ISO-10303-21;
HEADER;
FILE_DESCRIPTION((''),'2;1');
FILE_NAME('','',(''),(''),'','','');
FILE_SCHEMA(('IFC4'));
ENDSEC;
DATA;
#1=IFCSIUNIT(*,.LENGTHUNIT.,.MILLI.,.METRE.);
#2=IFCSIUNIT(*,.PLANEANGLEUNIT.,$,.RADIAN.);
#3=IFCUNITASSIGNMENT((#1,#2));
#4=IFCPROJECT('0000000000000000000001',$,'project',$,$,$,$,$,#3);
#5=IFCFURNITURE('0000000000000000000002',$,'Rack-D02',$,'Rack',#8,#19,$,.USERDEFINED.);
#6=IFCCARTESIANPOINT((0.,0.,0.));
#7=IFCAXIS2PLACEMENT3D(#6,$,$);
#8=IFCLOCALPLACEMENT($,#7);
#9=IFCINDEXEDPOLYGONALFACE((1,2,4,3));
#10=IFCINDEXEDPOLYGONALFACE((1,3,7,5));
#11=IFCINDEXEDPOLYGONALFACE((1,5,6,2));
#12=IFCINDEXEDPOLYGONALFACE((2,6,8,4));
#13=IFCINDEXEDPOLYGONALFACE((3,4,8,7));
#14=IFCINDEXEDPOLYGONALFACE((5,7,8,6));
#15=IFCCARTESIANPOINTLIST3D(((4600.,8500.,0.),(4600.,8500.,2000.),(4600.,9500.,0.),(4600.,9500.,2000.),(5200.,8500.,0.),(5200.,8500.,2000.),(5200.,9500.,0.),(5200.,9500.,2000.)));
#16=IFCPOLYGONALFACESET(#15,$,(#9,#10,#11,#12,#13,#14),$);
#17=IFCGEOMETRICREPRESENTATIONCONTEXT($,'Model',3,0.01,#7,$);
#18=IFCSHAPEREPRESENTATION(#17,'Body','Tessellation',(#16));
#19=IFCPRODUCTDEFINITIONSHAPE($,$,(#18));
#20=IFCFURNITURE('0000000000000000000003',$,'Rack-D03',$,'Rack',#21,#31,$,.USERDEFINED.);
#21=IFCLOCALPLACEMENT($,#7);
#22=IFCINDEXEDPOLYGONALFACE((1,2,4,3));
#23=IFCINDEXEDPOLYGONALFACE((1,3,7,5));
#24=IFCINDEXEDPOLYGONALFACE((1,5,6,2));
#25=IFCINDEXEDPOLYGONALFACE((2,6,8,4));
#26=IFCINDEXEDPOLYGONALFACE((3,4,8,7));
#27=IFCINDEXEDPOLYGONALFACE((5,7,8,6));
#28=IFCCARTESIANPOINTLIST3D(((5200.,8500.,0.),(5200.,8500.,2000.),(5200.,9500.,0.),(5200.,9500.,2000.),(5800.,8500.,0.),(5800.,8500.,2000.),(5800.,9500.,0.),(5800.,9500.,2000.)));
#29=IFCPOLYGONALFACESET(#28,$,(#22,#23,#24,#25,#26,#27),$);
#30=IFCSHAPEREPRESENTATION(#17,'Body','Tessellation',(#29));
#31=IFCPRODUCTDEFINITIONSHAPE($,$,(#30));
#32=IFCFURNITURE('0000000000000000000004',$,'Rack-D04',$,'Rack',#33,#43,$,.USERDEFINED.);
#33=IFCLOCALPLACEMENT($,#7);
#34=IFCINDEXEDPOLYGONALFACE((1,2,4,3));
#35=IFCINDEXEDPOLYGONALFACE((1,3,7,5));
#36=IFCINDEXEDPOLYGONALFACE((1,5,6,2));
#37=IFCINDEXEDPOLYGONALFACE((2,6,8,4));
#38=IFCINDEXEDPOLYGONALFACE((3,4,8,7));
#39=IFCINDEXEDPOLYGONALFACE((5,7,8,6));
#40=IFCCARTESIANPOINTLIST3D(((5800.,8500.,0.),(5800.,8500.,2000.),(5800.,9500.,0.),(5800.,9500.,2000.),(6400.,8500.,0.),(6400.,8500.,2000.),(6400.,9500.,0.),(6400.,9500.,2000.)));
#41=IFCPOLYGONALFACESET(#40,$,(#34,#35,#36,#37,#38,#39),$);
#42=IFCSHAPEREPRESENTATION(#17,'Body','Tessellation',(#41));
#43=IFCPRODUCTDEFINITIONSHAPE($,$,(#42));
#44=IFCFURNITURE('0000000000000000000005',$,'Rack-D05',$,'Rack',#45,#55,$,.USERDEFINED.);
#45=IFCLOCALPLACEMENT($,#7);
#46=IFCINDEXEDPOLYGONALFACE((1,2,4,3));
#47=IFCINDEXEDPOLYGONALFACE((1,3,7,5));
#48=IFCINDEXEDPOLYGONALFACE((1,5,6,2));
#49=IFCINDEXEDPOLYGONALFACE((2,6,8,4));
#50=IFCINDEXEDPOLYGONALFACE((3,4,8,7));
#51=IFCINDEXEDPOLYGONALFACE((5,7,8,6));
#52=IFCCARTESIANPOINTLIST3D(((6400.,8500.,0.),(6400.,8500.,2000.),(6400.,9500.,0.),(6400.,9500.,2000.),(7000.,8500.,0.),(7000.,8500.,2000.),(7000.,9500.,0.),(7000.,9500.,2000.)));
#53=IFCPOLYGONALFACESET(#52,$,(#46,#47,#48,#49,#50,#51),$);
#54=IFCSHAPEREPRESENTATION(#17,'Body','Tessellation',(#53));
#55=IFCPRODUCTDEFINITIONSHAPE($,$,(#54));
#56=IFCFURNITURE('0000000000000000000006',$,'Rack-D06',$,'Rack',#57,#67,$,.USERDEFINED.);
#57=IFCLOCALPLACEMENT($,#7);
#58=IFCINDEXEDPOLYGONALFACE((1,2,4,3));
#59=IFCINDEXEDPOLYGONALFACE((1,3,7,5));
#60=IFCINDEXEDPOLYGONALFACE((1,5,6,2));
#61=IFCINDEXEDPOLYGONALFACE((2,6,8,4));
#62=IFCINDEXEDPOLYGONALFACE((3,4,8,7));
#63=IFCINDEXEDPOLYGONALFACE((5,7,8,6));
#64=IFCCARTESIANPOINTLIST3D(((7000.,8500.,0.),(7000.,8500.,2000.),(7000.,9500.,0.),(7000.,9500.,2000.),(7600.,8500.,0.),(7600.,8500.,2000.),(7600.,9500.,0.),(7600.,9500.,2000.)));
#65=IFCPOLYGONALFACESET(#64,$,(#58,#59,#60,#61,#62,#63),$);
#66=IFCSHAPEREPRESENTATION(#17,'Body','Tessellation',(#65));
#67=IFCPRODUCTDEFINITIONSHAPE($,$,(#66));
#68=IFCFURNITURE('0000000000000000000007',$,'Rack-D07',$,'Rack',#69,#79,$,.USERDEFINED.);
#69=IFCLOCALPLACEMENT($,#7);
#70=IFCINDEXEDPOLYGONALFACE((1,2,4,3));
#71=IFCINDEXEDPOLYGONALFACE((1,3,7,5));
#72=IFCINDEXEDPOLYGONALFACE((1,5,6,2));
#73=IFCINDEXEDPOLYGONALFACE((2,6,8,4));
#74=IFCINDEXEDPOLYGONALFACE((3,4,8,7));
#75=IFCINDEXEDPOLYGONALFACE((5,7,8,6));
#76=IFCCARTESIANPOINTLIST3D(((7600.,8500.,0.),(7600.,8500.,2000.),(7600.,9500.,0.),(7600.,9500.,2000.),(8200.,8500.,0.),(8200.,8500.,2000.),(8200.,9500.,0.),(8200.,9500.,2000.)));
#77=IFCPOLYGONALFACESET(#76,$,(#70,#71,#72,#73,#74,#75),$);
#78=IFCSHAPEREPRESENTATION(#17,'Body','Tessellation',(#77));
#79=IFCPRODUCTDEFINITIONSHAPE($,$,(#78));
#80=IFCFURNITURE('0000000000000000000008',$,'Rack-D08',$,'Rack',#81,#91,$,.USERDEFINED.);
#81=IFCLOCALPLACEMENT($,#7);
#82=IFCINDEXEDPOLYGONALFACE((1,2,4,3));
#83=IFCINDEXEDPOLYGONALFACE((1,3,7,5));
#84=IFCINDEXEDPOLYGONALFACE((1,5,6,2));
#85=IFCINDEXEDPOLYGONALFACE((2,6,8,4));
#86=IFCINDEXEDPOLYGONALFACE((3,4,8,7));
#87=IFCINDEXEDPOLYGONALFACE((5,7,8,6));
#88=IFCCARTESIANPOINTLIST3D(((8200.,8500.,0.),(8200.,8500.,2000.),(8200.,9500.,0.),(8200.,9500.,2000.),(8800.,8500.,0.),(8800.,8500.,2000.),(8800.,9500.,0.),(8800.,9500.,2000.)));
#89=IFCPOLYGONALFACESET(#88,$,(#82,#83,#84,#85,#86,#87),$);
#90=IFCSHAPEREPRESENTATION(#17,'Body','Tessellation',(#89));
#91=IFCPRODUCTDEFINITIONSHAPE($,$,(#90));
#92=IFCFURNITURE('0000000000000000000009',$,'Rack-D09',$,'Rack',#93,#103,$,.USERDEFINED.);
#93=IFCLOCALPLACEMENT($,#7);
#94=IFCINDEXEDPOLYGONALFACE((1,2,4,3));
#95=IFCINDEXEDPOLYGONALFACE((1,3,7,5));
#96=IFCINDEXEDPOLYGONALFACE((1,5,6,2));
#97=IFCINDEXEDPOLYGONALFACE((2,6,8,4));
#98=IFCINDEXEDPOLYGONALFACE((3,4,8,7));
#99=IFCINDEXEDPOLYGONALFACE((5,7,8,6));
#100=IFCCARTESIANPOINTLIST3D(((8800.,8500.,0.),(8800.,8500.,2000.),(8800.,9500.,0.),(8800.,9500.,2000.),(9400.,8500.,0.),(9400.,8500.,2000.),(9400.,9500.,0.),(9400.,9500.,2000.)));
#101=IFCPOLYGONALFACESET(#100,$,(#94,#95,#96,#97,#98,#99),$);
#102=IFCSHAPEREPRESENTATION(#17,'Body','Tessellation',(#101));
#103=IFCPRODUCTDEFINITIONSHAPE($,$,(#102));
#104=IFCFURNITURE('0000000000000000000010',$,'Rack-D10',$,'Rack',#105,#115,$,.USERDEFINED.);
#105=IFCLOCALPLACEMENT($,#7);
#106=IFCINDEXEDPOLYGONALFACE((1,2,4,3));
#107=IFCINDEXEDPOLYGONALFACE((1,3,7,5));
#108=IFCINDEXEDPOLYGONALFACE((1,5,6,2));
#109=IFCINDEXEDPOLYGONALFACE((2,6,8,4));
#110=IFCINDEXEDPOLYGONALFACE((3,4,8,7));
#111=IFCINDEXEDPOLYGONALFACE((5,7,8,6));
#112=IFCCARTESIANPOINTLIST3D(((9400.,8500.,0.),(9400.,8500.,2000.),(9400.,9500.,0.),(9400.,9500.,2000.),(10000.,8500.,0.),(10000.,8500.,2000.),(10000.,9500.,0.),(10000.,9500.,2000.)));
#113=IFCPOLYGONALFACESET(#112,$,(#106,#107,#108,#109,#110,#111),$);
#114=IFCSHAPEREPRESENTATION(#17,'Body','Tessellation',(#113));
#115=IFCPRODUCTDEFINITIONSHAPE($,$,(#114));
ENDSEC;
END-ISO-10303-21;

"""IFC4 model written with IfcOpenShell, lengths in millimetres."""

from ifc_helpers import new_model, si_unit, frame, origin, place, context, project, polyline, outline, extrude, element, save


model = new_model("IFC4")

# Units and contexts
model_context = context("Model", 3, precision=0.01, world=origin())
ifc_project = project(units=[si_unit("LENGTHUNIT", "METRE", prefix="MILLI"), si_unit("PLANEANGLEUNIT", "RADIAN")])

# Furniture
for number, where, name in (
    (1, (4900.0, 9000.0, 0.0), "Rack-D02"),
    (2, (5500.0, 9000.0, 0.0), "Rack-D03"),
    (3, (6100.0, 9000.0, 0.0), "Rack-D04"),
    (4, (6700.0, 9000.0, 0.0), "Rack-D05"),
    (5, (7300.0, 9000.0, 0.0), "Rack-D06"),
    (6, (7900.0, 9000.0, 0.0), "Rack-D07"),
    (7, (8500.0, 9000.0, 0.0), "Rack-D08"),
    (8, (9100.0, 9000.0, 0.0), "Rack-D09"),
    (9, (9700.0, 9000.0, 0.0), "Rack-D10"),
):
    element("IfcFurniture", number, at=place(None, frame(where)), Name=name, ObjectType="Rack", PredefinedType="USERDEFINED", context=model_context, shape_type="SweptSolid", body=[
        extrude(outline(polyline([(-300.0, -500.0), (300.0, -500.0), (300.0, 500.0), (-300.0, 500.0), (-300.0, -500.0)])), origin(), (0.0, 0.0, 1.0), 2000.0),
    ])

save(model, "model.ifc")
